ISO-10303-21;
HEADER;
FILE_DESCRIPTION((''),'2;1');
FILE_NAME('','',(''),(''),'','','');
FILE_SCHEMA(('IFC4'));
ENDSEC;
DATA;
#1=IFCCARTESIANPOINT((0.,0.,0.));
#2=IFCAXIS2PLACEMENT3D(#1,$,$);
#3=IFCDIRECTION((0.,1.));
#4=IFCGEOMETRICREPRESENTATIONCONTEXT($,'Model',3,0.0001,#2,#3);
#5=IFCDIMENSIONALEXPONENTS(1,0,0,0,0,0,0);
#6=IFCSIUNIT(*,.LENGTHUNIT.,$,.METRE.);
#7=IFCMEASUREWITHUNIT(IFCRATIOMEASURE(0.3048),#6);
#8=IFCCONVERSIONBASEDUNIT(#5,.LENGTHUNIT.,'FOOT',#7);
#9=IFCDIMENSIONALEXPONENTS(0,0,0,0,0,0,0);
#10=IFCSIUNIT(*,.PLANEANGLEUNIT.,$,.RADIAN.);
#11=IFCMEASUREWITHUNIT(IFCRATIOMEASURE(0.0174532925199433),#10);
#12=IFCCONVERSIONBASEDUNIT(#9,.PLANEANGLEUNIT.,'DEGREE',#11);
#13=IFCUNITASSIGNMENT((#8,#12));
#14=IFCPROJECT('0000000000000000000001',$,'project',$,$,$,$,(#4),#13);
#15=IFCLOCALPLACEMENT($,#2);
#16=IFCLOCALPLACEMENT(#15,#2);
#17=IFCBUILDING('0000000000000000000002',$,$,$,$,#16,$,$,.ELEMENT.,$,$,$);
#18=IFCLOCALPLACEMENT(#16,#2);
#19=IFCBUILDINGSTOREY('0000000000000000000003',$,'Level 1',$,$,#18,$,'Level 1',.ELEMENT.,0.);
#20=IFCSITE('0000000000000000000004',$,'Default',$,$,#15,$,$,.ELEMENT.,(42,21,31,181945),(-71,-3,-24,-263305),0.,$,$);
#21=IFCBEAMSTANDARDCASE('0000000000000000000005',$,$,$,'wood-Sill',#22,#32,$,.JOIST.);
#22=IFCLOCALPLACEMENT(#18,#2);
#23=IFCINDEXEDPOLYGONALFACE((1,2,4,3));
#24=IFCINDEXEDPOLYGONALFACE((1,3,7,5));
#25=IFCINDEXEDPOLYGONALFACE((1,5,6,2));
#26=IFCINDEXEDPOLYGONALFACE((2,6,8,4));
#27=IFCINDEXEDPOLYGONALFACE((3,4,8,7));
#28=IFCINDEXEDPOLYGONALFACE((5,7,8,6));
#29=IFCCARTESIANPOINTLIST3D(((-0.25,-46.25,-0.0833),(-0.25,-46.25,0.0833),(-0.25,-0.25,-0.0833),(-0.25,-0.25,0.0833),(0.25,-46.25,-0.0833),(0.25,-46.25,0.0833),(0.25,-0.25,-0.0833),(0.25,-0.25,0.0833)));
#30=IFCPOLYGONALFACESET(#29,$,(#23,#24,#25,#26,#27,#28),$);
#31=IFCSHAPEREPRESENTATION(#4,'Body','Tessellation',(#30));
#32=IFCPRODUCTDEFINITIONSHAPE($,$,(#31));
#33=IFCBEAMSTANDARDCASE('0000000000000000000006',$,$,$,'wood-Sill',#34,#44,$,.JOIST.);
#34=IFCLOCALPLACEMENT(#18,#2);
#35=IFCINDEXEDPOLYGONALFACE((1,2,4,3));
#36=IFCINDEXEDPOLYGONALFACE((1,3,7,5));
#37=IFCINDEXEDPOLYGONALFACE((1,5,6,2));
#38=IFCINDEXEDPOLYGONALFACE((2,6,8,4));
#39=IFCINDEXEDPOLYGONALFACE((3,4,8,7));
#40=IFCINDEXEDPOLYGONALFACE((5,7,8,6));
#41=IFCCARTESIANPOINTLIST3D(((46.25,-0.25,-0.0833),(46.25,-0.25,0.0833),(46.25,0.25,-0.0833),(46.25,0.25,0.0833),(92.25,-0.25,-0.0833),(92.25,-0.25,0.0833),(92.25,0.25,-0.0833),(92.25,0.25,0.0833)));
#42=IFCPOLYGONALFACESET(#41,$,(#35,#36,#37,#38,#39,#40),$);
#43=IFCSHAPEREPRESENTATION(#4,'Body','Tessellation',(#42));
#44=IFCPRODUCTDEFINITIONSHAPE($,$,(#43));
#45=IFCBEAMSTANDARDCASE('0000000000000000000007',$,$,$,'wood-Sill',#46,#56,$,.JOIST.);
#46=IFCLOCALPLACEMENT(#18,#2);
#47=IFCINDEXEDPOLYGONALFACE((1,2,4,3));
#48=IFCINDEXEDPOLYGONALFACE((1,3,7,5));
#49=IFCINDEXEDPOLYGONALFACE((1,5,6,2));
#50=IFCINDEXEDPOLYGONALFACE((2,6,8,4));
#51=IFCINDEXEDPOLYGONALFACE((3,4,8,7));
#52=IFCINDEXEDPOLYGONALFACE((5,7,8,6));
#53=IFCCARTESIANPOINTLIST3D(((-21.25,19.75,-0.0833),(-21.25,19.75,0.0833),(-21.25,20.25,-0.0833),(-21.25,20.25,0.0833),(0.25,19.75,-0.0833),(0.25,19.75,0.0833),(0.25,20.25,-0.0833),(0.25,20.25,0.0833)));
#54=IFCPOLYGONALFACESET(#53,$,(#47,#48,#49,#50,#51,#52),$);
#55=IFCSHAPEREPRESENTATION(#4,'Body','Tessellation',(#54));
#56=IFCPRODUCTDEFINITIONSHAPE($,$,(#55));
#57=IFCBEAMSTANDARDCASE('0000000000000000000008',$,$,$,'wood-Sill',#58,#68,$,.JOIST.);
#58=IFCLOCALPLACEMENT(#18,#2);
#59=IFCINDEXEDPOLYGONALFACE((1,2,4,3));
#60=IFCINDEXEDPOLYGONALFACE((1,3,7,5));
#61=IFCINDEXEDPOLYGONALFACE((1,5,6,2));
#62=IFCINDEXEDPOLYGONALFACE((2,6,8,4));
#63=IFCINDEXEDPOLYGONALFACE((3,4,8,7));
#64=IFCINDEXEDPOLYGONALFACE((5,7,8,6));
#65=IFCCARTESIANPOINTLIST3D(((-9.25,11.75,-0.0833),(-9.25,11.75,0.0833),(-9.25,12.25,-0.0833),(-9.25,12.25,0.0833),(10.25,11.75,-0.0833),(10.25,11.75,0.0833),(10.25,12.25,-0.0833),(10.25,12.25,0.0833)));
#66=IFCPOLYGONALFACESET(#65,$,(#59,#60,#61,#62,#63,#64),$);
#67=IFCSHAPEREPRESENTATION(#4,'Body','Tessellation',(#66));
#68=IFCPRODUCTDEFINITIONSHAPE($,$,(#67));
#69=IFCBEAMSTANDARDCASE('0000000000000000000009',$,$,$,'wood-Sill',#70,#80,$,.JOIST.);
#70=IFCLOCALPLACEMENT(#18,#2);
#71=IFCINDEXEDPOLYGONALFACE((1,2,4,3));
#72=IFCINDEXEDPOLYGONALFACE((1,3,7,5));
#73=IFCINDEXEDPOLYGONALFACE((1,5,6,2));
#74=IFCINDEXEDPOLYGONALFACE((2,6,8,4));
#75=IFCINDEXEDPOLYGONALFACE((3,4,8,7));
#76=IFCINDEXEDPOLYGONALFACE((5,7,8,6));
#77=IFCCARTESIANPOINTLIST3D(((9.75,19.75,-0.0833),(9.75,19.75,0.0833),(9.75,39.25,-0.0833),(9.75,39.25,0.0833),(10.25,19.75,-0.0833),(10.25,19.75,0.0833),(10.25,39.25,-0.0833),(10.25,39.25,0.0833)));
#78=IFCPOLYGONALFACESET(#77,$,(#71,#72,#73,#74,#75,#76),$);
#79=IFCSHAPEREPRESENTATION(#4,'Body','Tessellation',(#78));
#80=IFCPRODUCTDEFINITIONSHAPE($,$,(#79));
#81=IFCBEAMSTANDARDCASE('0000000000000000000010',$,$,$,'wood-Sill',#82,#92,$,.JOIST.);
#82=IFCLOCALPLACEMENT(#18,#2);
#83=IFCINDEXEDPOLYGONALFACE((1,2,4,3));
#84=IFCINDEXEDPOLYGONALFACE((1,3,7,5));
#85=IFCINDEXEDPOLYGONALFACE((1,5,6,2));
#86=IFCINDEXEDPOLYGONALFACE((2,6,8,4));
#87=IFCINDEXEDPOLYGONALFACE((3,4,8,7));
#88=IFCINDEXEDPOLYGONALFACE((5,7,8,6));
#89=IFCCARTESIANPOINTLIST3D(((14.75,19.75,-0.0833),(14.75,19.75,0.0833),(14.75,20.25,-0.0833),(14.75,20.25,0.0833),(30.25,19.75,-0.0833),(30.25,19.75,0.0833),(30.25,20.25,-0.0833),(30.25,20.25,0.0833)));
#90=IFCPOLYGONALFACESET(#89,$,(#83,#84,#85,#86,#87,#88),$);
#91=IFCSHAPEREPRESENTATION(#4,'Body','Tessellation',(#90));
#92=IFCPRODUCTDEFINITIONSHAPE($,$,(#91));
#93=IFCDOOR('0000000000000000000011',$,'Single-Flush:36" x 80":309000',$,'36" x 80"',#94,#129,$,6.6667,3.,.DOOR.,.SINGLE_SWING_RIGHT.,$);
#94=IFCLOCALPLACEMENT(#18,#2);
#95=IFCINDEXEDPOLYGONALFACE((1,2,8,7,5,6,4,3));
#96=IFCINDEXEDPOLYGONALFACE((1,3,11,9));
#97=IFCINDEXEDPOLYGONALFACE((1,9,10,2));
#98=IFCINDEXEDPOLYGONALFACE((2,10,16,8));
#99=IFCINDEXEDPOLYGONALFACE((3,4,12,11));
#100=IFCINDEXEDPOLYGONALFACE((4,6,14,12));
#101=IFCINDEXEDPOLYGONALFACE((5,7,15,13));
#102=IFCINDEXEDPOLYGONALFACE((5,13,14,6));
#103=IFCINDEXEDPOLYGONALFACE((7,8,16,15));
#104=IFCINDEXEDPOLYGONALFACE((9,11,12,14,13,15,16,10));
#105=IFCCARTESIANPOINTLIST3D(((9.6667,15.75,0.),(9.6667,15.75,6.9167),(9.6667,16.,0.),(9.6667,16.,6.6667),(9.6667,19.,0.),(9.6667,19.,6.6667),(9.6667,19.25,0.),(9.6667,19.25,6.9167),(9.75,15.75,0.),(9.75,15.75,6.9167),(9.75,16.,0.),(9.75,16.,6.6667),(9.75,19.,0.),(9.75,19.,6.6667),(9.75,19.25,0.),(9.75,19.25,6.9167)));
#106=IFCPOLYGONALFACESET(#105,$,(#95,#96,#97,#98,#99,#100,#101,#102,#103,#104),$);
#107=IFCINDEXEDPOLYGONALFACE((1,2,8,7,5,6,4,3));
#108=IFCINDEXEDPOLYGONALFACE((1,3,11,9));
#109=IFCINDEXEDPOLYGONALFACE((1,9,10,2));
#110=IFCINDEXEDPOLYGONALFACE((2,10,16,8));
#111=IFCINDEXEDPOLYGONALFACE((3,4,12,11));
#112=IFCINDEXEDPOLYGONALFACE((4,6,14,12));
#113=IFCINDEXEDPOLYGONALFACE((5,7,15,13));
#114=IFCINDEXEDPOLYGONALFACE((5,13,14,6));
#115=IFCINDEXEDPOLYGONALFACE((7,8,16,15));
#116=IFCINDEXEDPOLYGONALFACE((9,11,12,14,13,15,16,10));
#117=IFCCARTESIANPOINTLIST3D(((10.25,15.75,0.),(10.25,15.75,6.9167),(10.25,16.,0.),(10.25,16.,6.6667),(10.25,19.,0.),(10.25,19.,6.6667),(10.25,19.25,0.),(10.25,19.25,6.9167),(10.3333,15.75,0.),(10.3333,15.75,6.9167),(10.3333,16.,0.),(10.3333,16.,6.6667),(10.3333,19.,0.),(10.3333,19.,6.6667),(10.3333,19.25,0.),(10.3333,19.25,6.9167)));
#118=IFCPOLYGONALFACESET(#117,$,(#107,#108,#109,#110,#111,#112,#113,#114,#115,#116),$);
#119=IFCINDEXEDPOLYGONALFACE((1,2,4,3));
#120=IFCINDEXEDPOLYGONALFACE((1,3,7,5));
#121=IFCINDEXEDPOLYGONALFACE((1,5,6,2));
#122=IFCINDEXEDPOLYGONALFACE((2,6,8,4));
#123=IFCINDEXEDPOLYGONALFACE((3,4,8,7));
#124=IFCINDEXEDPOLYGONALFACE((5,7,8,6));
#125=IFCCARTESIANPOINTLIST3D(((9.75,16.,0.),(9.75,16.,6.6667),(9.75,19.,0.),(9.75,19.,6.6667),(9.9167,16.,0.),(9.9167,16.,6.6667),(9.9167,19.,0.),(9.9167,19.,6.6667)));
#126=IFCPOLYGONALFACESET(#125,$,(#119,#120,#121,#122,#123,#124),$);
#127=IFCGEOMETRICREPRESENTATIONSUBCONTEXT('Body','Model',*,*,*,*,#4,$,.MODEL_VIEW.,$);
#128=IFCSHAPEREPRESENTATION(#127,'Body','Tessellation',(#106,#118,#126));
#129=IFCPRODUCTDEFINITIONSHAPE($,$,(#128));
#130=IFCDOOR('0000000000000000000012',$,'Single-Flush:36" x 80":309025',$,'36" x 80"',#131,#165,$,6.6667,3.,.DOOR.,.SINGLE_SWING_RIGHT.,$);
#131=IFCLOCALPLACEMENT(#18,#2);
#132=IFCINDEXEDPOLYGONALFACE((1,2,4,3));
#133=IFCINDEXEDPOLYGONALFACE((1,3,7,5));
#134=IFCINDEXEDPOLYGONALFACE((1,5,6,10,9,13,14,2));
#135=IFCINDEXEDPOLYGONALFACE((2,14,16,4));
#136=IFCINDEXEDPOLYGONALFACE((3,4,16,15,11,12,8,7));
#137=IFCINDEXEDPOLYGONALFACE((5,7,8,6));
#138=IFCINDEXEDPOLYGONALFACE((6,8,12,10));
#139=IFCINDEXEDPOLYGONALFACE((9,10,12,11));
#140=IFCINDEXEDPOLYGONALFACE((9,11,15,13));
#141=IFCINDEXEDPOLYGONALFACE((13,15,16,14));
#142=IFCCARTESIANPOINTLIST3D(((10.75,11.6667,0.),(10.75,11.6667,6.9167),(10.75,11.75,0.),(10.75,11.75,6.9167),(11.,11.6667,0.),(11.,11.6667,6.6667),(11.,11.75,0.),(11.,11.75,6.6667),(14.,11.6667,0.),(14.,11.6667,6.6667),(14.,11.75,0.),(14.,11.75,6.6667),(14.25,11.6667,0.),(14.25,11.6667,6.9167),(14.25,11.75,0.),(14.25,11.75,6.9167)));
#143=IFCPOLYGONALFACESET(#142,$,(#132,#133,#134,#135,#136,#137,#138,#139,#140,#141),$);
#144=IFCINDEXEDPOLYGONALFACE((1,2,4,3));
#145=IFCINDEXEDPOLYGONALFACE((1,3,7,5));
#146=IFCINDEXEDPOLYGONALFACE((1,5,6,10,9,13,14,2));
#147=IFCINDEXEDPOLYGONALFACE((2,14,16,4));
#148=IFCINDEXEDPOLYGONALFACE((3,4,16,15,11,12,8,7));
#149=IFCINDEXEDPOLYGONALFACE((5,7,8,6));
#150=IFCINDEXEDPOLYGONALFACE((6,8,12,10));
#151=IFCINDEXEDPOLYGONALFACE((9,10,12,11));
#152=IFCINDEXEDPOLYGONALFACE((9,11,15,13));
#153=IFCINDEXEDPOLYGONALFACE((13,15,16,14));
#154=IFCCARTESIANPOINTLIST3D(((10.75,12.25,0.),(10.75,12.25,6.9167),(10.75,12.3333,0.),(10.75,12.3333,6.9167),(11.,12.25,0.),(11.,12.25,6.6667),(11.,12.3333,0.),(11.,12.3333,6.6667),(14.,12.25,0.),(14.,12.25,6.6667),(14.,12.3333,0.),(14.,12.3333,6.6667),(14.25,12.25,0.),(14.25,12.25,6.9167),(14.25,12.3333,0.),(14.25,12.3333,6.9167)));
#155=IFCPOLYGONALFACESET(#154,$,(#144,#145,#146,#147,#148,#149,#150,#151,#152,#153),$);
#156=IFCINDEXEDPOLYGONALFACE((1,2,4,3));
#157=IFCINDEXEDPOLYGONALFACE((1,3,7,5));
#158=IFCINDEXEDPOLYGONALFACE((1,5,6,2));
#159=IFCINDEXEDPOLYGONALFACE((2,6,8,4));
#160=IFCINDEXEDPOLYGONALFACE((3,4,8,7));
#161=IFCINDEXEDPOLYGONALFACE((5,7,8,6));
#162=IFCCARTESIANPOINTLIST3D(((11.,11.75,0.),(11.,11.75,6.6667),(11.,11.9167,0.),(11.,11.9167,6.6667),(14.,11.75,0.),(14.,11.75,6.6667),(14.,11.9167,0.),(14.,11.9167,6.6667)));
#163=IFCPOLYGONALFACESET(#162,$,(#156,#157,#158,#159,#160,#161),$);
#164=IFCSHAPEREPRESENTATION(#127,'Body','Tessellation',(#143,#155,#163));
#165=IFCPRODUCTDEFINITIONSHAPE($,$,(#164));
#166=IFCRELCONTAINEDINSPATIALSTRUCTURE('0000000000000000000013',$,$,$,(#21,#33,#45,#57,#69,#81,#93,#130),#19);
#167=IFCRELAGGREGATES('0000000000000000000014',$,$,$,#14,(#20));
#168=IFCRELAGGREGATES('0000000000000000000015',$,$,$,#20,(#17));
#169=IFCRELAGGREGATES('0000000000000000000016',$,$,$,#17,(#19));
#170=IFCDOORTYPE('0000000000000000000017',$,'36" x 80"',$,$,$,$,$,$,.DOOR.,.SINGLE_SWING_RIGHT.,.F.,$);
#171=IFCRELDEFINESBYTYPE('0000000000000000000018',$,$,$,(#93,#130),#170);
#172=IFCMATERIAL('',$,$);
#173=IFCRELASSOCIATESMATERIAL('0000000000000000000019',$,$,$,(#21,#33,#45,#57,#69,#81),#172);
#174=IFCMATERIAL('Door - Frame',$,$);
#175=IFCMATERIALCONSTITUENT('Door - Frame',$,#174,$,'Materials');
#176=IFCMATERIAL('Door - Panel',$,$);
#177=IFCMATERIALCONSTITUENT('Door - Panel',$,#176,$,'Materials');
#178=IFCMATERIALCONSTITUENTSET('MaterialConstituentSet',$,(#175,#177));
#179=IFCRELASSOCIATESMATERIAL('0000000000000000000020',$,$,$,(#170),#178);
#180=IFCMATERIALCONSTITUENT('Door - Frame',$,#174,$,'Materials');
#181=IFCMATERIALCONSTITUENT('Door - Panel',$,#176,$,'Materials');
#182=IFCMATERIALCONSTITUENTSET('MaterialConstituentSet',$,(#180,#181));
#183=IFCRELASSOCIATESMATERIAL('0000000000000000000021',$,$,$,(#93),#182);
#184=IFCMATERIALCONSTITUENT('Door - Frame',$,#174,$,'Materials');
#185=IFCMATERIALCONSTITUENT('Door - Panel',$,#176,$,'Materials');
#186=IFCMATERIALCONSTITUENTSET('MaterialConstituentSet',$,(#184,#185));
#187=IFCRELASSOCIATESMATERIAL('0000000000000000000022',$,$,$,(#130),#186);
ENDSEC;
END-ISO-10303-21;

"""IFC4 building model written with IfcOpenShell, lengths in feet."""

from ifc_helpers import new_model, entity, si_unit, converted_unit, direction, frame, origin, origin_with_axes, origin_2d_with_axis, place, context, subcontext, project, spatial, polyline, rectangle, outline, extrude, source, transform, mapped, material, constituent, constituent_set, type_object, type_shapes, element, save


model = new_model("IFC4")

# Units and contexts
model_context = context("Model", 3, precision=0.0001, world=origin(), true_north=direction((0.0, 1.0)))
body_context = subcontext(model_context, "Body", "Model", "MODEL_VIEW")
ifc_project = project(units=[converted_unit("LENGTHUNIT", "FOOT", entity("IfcRatioMeasure", 0.3048), si_unit("LENGTHUNIT", "METRE"), dimensions=[1, 0, 0, 0, 0, 0, 0]), converted_unit("PLANEANGLEUNIT", "DEGREE", entity("IfcRatioMeasure", 0.0174532925199433), si_unit("PLANEANGLEUNIT", "RADIAN"), dimensions=[0, 0, 0, 0, 0, 0, 0])], contexts=[model_context])

# Site, building, storey
site_placement = place(None, origin())
site = spatial("IfcSite", under=ifc_project, at=site_placement, Name="Default", CompositionType="ELEMENT", RefLatitude=(42, 21, 31, 181945), RefLongitude=(-71, -3, -24, -263305), RefElevation=0.0)
building_placement = place(site_placement, origin())
building = spatial("IfcBuilding", under=site, at=building_placement, CompositionType="ELEMENT")
storey_placement = place(building_placement, origin())
storey = spatial("IfcBuildingStorey", under=building, at=storey_placement, Name="Level 1", LongName="Level 1", CompositionType="ELEMENT", Elevation=0.0)

# Beams
ifc_material_1 = material(Name="")
placement_1 = place(storey_placement, frame((0.0, -0.25, 0.0), z_axis=(0.0, 0.0, 1.0), x_axis=(0.0, 1.0, 0.0)))
beam_1_placement = place(placement_1, frame((0.0, 0.0, 0.0), z_axis=(-1.0, 0.0, 0.0), x_axis=(0.0, 0.0, 1.0)))
element("IfcBeamStandardCase", 1, at=beam_1_placement, inside=storey, material=ifc_material_1, ObjectType="wood-Sill", PredefinedType="JOIST", context=model_context, shape_type="SweptSolid", body=[
    extrude(rectangle(XDim=0.1667, YDim=0.5), origin_with_axes(), (0.0, 0.0, 1.0), 46.0),
])
placement_2 = place(storey_placement, frame((46.25, 0.0, 0.0), z_axis=(0.0, 0.0, 1.0), x_axis=(-1.0, 0.0, 0.0)))
beam_2_placement = place(placement_2, frame((0.0, 0.0, 0.0), z_axis=(-1.0, 0.0, 0.0), x_axis=(0.0, 0.0, 1.0)))
element("IfcBeamStandardCase", 2, at=beam_2_placement, inside=storey, material=ifc_material_1, ObjectType="wood-Sill", PredefinedType="JOIST", context=model_context, shape_type="SweptSolid", body=[
    extrude(rectangle(XDim=0.1667, YDim=0.5), origin_with_axes(), (0.0, 0.0, 1.0), 46.0),
])
placement_3 = place(storey_placement, frame((0.25, 20.0, 0.0)))
beam_3_placement = place(placement_3, frame((0.0, 0.0, 0.0), z_axis=(-1.0, 0.0, 0.0), x_axis=(0.0, 0.0, 1.0)))
element("IfcBeamStandardCase", 3, at=beam_3_placement, inside=storey, material=ifc_material_1, ObjectType="wood-Sill", PredefinedType="JOIST", context=model_context, shape_type="SweptSolid", body=[
    extrude(rectangle(XDim=0.1667, YDim=0.5), origin_with_axes(), (0.0, 0.0, 1.0), 21.5),
])
placement_4 = place(storey_placement, frame((10.25, 12.0, 0.0)))
beam_4_placement = place(placement_4, frame((0.0, 0.0, 0.0), z_axis=(-1.0, 0.0, 0.0), x_axis=(0.0, 0.0, 1.0)))
element("IfcBeamStandardCase", 4, at=beam_4_placement, inside=storey, material=ifc_material_1, ObjectType="wood-Sill", PredefinedType="JOIST", context=model_context, shape_type="SweptSolid", body=[
    extrude(rectangle(XDim=0.1667, YDim=0.5), origin_with_axes(), (0.0, 0.0, 1.0), 19.5),
])
placement_5 = place(storey_placement, frame((10.0, 19.75, 0.0), z_axis=(0.0, 0.0, 1.0), x_axis=(0.0, -1.0, 0.0)))
beam_5_placement = place(placement_5, frame((0.0, 0.0, 0.0), z_axis=(-1.0, 0.0, 0.0), x_axis=(0.0, 0.0, 1.0)))
element("IfcBeamStandardCase", 5, at=beam_5_placement, inside=storey, material=ifc_material_1, ObjectType="wood-Sill", PredefinedType="JOIST", context=model_context, shape_type="SweptSolid", body=[
    extrude(rectangle(XDim=0.1667, YDim=0.5), origin_with_axes(), (0.0, 0.0, 1.0), 19.5),
])
placement_6 = place(storey_placement, frame((30.25, 20.0, 0.0)))
beam_6_placement = place(placement_6, frame((0.0, 0.0, 0.0), z_axis=(-1.0, 0.0, 0.0), x_axis=(0.0, 0.0, 1.0)))
element("IfcBeamStandardCase", 6, at=beam_6_placement, inside=storey, material=ifc_material_1, ObjectType="wood-Sill", PredefinedType="JOIST", context=model_context, shape_type="SweptSolid", body=[
    extrude(rectangle(XDim=0.1667, YDim=0.5), origin_with_axes(), (0.0, 0.0, 1.0), 15.5),
])

# Doors
ifc_material_2 = material(Name="Door - Frame")
ifc_constituent_1 = constituent(ifc_material_2, Name="Door - Frame", Category="Materials")
ifc_material_3 = material(Name="Door - Panel")
ifc_constituent_2 = constituent(ifc_material_3, Name="Door - Panel", Category="Materials")
ifc_constituent_set_1 = constituent_set(constituents=[ifc_constituent_1, ifc_constituent_2], Name="MaterialConstituentSet")
ifc_constituent_3 = constituent(ifc_material_2, Name="Door - Frame", Category="Materials")
ifc_constituent_4 = constituent(ifc_material_3, Name="Door - Panel", Category="Materials")
ifc_constituent_set_2 = constituent_set(constituents=[ifc_constituent_3, ifc_constituent_4], Name="MaterialConstituentSet")
door_type_1 = type_object("IfcDoorType", Name="36\" x 80\"", OperationType="SINGLE_SWING_RIGHT", ParameterTakesPrecedence=False, PredefinedType="DOOR", material=ifc_constituent_set_2)
shared_shape_1 = source(origin(), body_context, "Body", "SweptSolid", [
    extrude(outline(polyline([(-1.75, -3.5208), (1.75, -3.5208), (1.75, 3.3958), (1.5, 3.3958), (1.5, -3.2708), (-1.5, -3.2708), (-1.5, 3.3958), (-1.75, 3.3958), (-1.75, -3.5208)])), frame((1.5, 0.5, 3.3958), z_axis=(0.0, 1.0, 0.0), x_axis=(1.0, 0.0, 0.0)), (0.0, 0.0, 1.0), 0.0833),
    extrude(outline(polyline([(-3.5208, -1.75), (3.3958, -1.75), (3.3958, -1.5), (-3.2708, -1.5), (-3.2708, 1.5), (3.3958, 1.5), (3.3958, 1.75), (-3.5208, 1.75), (-3.5208, -1.75)])), frame((1.5, -0.0833, 3.3958), z_axis=(0.0, 1.0, 0.0), x_axis=(0.0, 0.0, -1.0)), (0.0, 0.0, 1.0), 0.0833),
    extrude(rectangle(XDim=0.1667, YDim=3.0, at=origin_2d_with_axis()), frame((1.5, 0.4167, 0.0), z_axis=(0.0, 0.0, 1.0), x_axis=(0.0, 1.0, 0.0)), (0.0, 0.0, 1.0), 6.6667),
])
type_shapes(door_type_1, [shared_shape_1])
placement_7 = place(placement_5, frame((3.75, 0.25, 0.0)))
door_1_placement = place(placement_7, frame((0.0, 0.0, 0.0), z_axis=(0.0, 0.0, 1.0), x_axis=(-1.0, 0.0, 0.0)))
element("IfcDoor", 7, at=door_1_placement, inside=storey, type_object=door_type_1, material=ifc_constituent_set_1, Name="Single-Flush:36\" x 80\":309000", ObjectType="36\" x 80\"", OperationType="SINGLE_SWING_RIGHT", OverallHeight=6.6667, OverallWidth=3.0, PredefinedType="DOOR", context=body_context, shape_type="MappedRepresentation", body=[
    mapped(shared_shape_1, transform((0.0, 0.0, 0.0), scale=1.0)),
])
ifc_constituent_5 = constituent(ifc_material_2, Name="Door - Frame", Category="Materials")
ifc_constituent_6 = constituent(ifc_material_3, Name="Door - Panel", Category="Materials")
ifc_constituent_set_3 = constituent_set(constituents=[ifc_constituent_5, ifc_constituent_6], Name="MaterialConstituentSet")
placement_8 = place(placement_4, frame((3.75, 0.25, 0.0)))
door_2_placement = place(placement_8, frame((0.0, 0.0, 0.0), z_axis=(0.0, 0.0, 1.0), x_axis=(-1.0, 0.0, 0.0)))
element("IfcDoor", 8, at=door_2_placement, inside=storey, type_object=door_type_1, material=ifc_constituent_set_3, Name="Single-Flush:36\" x 80\":309025", ObjectType="36\" x 80\"", OperationType="SINGLE_SWING_RIGHT", OverallHeight=6.6667, OverallWidth=3.0, PredefinedType="DOOR", context=body_context, shape_type="MappedRepresentation", body=[
    mapped(shared_shape_1, transform((0.0, 0.0, 0.0), scale=1.0)),
])

save(model, "model.ifc")
